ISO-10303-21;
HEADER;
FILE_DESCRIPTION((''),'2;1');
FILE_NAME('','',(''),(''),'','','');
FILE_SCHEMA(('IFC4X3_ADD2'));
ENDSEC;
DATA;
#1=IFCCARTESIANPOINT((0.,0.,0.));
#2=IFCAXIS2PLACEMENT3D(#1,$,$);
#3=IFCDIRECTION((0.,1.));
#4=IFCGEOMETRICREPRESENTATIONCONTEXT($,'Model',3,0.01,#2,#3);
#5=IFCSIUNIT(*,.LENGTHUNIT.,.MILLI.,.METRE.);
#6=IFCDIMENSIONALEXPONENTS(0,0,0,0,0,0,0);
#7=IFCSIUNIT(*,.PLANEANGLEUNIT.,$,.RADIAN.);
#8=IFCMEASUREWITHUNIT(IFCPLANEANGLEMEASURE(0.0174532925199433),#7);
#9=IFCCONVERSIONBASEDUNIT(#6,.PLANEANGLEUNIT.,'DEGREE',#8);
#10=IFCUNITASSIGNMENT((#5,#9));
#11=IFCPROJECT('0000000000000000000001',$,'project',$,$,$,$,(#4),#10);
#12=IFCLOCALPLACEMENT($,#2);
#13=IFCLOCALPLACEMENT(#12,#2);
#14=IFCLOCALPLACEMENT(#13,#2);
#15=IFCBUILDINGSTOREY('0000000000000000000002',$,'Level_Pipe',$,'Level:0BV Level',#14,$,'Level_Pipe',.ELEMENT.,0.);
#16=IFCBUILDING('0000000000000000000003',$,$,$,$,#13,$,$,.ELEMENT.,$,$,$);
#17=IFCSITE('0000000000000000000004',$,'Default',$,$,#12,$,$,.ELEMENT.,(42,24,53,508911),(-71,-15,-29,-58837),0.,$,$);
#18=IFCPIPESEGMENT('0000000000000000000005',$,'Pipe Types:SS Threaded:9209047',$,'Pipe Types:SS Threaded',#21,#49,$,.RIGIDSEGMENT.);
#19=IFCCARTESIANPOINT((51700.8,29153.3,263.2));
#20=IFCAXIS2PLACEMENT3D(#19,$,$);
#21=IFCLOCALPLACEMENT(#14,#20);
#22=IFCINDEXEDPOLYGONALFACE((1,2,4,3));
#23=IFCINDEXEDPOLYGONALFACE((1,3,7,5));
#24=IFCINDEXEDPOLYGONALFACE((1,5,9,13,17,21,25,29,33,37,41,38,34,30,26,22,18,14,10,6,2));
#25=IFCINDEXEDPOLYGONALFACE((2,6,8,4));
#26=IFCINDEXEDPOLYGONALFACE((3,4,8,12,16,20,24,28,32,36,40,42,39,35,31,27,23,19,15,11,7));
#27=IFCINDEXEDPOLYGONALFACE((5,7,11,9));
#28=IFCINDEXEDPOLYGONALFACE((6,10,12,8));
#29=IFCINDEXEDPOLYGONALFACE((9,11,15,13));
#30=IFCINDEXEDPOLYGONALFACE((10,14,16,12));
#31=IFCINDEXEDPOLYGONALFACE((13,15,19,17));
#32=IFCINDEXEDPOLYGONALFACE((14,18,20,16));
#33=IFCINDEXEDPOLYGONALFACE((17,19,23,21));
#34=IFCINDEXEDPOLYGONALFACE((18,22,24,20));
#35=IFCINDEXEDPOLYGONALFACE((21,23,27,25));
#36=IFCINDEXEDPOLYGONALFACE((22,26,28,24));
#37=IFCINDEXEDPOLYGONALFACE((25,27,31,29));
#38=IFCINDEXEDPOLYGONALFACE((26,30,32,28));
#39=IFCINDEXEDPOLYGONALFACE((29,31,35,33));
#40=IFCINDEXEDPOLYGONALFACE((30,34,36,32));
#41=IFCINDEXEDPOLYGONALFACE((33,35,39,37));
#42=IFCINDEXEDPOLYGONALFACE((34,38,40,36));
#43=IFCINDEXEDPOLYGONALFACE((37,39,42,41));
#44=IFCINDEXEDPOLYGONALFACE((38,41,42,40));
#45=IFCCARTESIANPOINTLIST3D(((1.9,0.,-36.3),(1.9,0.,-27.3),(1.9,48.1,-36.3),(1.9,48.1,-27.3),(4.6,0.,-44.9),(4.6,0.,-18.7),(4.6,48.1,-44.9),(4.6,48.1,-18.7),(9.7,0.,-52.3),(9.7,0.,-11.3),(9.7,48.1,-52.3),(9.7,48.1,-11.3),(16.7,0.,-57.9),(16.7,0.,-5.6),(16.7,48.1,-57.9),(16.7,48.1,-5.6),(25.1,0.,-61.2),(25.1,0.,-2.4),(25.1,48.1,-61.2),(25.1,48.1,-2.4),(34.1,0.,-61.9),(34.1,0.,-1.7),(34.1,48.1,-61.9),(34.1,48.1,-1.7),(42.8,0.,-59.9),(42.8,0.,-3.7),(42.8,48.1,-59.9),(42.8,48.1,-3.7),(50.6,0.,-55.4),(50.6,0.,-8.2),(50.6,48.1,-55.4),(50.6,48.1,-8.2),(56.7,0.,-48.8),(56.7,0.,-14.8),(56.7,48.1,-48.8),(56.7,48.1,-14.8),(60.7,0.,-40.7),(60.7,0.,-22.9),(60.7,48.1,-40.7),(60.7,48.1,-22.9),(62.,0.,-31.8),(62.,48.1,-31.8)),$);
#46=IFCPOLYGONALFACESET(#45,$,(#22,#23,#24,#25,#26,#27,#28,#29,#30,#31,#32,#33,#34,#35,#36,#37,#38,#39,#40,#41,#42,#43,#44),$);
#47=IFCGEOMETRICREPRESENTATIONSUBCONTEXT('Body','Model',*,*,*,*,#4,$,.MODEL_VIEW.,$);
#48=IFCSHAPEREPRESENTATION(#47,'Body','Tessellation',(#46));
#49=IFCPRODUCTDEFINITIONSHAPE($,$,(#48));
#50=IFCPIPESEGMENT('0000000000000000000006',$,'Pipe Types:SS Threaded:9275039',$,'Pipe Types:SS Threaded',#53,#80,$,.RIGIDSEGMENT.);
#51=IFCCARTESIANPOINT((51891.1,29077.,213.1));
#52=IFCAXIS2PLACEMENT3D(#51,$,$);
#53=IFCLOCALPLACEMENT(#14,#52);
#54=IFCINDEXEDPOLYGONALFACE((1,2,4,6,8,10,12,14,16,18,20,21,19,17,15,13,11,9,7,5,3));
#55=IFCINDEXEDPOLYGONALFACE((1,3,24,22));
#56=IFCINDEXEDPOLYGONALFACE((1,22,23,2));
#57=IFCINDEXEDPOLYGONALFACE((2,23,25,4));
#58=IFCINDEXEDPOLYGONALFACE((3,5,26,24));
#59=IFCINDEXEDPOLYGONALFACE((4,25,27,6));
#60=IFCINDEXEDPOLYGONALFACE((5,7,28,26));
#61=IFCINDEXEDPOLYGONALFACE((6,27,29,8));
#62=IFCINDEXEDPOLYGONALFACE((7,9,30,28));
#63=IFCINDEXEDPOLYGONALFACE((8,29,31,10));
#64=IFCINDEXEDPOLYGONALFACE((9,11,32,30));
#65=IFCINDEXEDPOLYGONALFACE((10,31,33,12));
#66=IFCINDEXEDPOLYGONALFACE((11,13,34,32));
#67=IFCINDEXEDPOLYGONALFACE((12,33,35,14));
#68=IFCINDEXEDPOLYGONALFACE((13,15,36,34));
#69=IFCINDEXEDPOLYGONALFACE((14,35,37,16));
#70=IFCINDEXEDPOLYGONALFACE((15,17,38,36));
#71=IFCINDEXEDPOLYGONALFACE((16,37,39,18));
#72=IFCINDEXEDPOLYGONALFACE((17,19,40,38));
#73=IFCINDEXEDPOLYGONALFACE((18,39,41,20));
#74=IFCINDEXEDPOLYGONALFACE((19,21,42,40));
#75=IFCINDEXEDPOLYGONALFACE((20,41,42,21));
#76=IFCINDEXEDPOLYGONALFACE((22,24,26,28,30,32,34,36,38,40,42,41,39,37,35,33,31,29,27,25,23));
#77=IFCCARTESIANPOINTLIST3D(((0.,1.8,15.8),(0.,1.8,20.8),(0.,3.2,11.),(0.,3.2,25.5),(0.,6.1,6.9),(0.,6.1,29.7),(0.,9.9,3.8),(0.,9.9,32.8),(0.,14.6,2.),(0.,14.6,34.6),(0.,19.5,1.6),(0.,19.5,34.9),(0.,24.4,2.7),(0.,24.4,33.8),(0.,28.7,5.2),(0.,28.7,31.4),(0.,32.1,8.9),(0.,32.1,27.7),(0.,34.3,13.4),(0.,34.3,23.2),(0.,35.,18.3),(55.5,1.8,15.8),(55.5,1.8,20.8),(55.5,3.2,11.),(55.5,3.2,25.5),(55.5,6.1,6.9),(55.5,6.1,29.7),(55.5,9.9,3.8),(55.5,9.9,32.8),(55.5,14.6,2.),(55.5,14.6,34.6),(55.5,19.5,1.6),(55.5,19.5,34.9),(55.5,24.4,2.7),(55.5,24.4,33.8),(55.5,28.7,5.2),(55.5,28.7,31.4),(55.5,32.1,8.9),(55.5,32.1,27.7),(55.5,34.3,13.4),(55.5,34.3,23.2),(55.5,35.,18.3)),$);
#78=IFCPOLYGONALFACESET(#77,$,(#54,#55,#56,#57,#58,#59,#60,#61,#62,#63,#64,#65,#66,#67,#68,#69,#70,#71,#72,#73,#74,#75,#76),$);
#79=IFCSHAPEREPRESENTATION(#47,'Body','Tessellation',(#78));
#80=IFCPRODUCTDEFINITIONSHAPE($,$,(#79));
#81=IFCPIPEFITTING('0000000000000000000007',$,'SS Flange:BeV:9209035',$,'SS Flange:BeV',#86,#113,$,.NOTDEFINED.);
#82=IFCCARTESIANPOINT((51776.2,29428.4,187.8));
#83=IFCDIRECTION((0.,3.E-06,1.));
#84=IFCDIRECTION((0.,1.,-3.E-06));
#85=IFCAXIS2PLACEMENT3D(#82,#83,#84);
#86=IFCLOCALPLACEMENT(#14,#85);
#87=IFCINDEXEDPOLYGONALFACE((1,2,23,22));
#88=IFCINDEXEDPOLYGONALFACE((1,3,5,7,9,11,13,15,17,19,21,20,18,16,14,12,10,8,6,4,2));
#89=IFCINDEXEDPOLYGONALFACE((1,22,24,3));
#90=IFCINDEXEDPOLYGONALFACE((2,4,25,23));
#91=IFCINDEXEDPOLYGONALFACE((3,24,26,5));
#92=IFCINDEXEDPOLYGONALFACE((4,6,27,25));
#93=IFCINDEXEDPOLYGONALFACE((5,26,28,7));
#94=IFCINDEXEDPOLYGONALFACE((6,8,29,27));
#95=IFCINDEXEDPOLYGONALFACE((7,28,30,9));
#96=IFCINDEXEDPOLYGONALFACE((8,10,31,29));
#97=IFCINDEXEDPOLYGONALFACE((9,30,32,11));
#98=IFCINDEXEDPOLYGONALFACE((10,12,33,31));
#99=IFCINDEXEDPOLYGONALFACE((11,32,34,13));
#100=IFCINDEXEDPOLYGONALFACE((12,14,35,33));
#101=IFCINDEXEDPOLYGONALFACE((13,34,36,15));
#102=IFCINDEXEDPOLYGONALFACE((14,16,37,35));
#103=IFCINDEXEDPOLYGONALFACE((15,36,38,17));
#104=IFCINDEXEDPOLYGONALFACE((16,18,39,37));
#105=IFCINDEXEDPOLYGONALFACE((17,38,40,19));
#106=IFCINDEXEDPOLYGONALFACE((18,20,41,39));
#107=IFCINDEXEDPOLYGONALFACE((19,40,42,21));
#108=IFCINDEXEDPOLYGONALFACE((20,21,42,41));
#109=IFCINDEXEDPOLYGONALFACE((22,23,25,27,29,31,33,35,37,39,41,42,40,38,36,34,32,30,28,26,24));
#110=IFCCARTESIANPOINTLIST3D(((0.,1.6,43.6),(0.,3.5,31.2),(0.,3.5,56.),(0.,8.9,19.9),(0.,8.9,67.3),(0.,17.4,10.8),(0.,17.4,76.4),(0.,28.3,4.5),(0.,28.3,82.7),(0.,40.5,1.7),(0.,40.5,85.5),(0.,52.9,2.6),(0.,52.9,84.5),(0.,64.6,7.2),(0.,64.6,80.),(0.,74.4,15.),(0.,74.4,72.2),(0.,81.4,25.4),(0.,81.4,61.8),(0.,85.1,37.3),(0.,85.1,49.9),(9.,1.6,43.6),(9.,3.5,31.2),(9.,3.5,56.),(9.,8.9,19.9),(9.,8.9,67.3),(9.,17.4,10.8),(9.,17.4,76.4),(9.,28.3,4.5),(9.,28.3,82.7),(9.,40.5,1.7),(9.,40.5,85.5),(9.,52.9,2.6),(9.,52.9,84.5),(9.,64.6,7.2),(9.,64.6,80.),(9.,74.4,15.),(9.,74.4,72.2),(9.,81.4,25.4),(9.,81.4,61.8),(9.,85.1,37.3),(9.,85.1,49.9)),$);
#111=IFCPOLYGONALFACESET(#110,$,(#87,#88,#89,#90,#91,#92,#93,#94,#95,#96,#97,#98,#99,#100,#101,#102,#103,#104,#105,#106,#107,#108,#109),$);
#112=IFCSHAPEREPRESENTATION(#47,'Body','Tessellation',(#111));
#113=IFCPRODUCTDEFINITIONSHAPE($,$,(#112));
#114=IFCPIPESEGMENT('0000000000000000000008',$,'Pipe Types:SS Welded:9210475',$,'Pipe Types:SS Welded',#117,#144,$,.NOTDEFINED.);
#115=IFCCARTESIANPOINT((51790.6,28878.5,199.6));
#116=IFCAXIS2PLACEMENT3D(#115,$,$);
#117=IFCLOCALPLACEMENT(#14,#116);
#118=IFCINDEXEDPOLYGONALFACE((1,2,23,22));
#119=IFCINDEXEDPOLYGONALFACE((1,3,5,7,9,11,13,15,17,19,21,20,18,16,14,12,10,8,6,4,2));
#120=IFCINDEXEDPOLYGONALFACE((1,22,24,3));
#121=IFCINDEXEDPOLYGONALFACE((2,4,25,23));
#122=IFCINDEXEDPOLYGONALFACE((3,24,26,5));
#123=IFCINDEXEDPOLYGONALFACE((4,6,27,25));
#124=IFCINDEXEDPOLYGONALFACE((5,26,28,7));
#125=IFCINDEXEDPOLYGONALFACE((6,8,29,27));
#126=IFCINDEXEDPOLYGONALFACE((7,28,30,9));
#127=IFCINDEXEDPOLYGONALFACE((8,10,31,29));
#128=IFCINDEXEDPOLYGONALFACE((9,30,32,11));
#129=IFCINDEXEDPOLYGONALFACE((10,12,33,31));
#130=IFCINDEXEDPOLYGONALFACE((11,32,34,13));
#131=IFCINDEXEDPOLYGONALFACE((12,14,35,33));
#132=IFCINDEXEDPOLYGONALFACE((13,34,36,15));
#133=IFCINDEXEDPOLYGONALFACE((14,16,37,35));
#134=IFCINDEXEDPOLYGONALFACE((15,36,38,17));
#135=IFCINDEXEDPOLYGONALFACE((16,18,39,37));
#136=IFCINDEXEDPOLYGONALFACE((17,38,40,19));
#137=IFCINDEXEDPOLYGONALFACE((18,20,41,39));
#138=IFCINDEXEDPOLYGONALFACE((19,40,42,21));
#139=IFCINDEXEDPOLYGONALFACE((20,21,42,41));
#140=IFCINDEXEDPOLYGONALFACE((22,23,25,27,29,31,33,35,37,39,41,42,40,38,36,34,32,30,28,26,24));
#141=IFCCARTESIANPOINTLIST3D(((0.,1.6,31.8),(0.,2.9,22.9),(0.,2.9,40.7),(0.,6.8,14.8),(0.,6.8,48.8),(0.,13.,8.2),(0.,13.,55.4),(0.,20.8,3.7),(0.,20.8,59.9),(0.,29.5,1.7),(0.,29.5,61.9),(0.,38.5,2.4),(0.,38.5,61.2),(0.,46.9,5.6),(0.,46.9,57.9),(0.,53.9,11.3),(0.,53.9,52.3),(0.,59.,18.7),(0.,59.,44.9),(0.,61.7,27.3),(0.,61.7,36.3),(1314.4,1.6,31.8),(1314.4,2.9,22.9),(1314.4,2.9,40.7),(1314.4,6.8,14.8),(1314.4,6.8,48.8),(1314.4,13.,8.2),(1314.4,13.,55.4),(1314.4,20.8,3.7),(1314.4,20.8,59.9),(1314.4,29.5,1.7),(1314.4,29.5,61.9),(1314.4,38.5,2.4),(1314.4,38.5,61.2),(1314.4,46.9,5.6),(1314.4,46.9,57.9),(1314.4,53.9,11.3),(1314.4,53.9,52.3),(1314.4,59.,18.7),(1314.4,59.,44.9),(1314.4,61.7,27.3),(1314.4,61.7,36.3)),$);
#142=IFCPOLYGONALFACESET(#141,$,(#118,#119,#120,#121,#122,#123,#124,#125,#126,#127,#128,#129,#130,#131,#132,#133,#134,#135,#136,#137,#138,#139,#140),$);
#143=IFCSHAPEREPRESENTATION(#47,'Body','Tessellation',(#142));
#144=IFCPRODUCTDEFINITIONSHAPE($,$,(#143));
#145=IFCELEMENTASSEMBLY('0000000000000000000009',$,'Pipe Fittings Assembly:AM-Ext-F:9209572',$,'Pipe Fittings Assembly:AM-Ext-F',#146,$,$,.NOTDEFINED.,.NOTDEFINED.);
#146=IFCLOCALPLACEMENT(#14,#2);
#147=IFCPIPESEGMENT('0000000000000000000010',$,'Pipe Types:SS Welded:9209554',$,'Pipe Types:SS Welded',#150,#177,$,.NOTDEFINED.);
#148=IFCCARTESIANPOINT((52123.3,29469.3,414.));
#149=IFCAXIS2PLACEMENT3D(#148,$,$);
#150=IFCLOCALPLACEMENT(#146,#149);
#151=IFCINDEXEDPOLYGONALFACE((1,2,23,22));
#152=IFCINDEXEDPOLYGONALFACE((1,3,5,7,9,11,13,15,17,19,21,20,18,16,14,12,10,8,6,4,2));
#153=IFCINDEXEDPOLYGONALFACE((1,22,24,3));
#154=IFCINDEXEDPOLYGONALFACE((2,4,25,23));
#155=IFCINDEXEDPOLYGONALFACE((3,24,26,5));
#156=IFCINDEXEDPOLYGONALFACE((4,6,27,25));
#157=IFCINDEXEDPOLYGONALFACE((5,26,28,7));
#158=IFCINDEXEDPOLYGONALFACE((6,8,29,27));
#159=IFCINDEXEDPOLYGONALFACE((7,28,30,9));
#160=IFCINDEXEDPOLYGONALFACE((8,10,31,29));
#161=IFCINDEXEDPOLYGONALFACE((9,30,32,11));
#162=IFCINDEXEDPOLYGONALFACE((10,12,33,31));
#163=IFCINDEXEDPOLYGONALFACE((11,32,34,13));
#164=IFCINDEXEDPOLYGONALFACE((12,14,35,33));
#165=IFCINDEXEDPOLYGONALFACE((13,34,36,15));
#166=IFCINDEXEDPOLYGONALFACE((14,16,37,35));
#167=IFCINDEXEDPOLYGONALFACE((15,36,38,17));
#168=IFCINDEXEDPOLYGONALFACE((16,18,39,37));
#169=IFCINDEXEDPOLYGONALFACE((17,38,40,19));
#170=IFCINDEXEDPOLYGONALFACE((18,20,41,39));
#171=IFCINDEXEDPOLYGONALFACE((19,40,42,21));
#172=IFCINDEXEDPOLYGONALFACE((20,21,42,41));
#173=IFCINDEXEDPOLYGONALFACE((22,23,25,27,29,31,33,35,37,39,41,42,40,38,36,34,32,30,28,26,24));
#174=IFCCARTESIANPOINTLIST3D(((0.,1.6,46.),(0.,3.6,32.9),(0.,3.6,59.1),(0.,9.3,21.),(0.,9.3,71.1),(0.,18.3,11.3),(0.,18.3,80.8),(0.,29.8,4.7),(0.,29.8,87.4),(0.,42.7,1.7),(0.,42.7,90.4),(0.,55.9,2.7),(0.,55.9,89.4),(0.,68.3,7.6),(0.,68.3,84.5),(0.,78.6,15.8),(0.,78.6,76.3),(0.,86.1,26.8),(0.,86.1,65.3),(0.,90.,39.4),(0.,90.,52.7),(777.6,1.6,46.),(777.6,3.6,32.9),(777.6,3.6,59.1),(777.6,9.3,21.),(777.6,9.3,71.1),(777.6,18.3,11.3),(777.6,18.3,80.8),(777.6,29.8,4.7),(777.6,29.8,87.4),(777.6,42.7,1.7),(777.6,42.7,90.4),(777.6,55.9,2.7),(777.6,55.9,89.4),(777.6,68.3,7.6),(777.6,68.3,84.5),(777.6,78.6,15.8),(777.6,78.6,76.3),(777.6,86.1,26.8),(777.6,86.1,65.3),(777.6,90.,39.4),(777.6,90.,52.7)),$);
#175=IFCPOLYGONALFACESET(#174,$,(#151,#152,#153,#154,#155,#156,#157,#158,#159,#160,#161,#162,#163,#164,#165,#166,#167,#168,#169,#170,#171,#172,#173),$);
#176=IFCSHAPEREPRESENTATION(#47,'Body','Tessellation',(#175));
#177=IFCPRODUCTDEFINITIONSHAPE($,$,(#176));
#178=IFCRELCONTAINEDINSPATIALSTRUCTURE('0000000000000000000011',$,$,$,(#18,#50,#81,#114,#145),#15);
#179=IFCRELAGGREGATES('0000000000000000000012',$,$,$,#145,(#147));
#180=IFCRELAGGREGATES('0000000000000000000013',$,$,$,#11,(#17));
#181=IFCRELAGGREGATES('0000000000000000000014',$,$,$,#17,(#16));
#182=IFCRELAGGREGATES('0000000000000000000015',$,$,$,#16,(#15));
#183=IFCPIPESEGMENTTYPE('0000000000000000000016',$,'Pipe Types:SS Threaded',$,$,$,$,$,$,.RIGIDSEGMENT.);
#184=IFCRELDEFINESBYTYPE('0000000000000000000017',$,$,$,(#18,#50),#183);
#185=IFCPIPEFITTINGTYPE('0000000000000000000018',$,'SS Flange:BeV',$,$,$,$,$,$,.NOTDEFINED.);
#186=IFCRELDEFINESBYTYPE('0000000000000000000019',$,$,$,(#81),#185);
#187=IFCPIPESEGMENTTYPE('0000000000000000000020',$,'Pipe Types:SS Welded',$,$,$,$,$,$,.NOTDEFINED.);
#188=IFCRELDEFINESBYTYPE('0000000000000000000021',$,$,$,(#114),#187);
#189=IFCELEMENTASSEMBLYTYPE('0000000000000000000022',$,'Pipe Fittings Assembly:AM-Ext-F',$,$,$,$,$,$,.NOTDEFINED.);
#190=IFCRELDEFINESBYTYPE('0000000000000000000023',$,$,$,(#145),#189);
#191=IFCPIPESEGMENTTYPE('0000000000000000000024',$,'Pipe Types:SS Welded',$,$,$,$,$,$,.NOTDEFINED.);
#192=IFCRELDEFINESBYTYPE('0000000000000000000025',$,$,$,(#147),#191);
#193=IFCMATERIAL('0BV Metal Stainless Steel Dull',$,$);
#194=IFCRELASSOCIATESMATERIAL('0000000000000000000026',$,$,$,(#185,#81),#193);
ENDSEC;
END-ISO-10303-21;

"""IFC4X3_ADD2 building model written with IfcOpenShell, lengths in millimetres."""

from ifc_helpers import new_model, entity, si_unit, converted_unit, direction, frame, frame_2d, origin, place, context, subcontext, project, spatial, circle, extrude, source, transform, mapped, material, type_object, type_shapes, element, aggregate, save


model = new_model("IFC4X3_ADD2")

# Units and contexts
model_context = context("Model", 3, precision=0.01, world=origin(), true_north=direction((0.0, 1.0)))
body_context = subcontext(model_context, "Body", "Model", "MODEL_VIEW")
ifc_project = project(units=[si_unit("LENGTHUNIT", "METRE", prefix="MILLI"), converted_unit("PLANEANGLEUNIT", "DEGREE", entity("IfcPlaneAngleMeasure", 0.0174532925199433), si_unit("PLANEANGLEUNIT", "RADIAN"), dimensions=[0, 0, 0, 0, 0, 0, 0])], contexts=[model_context])

# Site, building, storey
site_placement = place(None, origin())
site = spatial("IfcSite", under=ifc_project, at=site_placement, Name="Default", CompositionType="ELEMENT", RefLatitude=(42, 24, 53, 508911), RefLongitude=(-71, -15, -29, -58837), RefElevation=0.0)
building_placement = place(site_placement, origin())
building = spatial("IfcBuilding", under=site, at=building_placement, CompositionType="ELEMENT")
storey_placement = place(building_placement, origin())
storey = spatial("IfcBuildingStorey", under=building, at=storey_placement, Name="Level_Pipe", ObjectType="Level:0BV Level", LongName="Level_Pipe", CompositionType="ELEMENT", Elevation=0.0)

# Pipe segments
pipe_segment_type_1 = type_object("IfcPipeSegmentType", Name="Pipe Types:SS Threaded", PredefinedType="RIGIDSEGMENT")
pipe_segment_1_placement = place(storey_placement, frame((51700.8, 29153.3, 263.2)))
element("IfcPipeSegment", 1, at=pipe_segment_1_placement, inside=storey, type_object=pipe_segment_type_1, Name="Pipe Types:SS Threaded:9209047", ObjectType="Pipe Types:SS Threaded", PredefinedType="RIGIDSEGMENT", context=body_context, shape_type="SweptSolid", body=[
    extrude(circle(Radius=30.2, at=frame_2d((0.0, 0.0), x_axis=(1.0, 0.0))), frame((31.8, 0.0, -31.8), z_axis=(0.0, 1.0, 0.0), x_axis=(1.0, 0.0, 0.0)), (0.0, 0.0, 1.0), 48.1),
])
pipe_segment_2_placement = place(storey_placement, frame((51891.1, 29077.0, 213.1)))
element("IfcPipeSegment", 2, at=pipe_segment_2_placement, inside=storey, type_object=pipe_segment_type_1, Name="Pipe Types:SS Threaded:9275039", ObjectType="Pipe Types:SS Threaded", PredefinedType="RIGIDSEGMENT", context=body_context, shape_type="SweptSolid", body=[
    extrude(circle(Radius=16.7, at=frame_2d((0.0, 0.0), x_axis=(1.0, 0.0))), frame((0.0, 18.3, 18.3), z_axis=(1.0, 0.0, 0.0), x_axis=(0.0, 1.0, 0.0)), (0.0, 0.0, 1.0), 55.5),
])

# Pipe fitting
ifc_material_1 = material(Name="0BV Metal Stainless Steel Dull")
pipe_fitting_type_1 = type_object("IfcPipeFittingType", Name="SS Flange:BeV", PredefinedType="NOTDEFINED", material=ifc_material_1)
shared_shape_1 = source(origin(), body_context, "Body", "SweptSolid", [
    extrude(circle(Radius=42.0, at=frame_2d((0.0, 0.0), x_axis=(1.0, 0.0))), frame((0.0, 43.6, 43.6), z_axis=(1.0, 0.0, 0.0), x_axis=(0.0, -1.0, 0.0)), (0.0, 0.0, 1.0), 9.0),
])
type_shapes(pipe_fitting_type_1, [shared_shape_1])
pipe_fitting_1_placement = place(storey_placement, frame((51776.2, 29428.4, 187.8), z_axis=(0.0, 0.000003, 1.0), x_axis=(0.0, 1.0, -0.000003)))
element("IfcPipeFitting", 3, at=pipe_fitting_1_placement, inside=storey, type_object=pipe_fitting_type_1, material=ifc_material_1, Name="SS Flange:BeV:9209035", ObjectType="SS Flange:BeV", PredefinedType="NOTDEFINED", context=body_context, shape_type="MappedRepresentation", body=[
    mapped(shared_shape_1, transform((0.0, 0.0, 0.0), scale=1.0)),
])

# Pipe segment
pipe_segment_type_2 = type_object("IfcPipeSegmentType", Name="Pipe Types:SS Welded", PredefinedType="NOTDEFINED")
pipe_segment_3_placement = place(storey_placement, frame((51790.6, 28878.5, 199.6)))
element("IfcPipeSegment", 4, at=pipe_segment_3_placement, inside=storey, type_object=pipe_segment_type_2, Name="Pipe Types:SS Welded:9210475", ObjectType="Pipe Types:SS Welded", PredefinedType="NOTDEFINED", context=body_context, shape_type="SweptSolid", body=[
    extrude(circle(Radius=30.2, at=frame_2d((0.0, 0.0), x_axis=(1.0, 0.0))), frame((0.0, 31.8, 31.8), z_axis=(1.0, 0.0, 0.0), x_axis=(0.0, -1.0, 0.0)), (0.0, 0.0, 1.0), 1314.4),
])

# Element assembly, pipe segment
element_assembly_type = type_object("IfcElementAssemblyType", Name="Pipe Fittings Assembly:AM-Ext-F", PredefinedType="NOTDEFINED")
assembly_placement = place(storey_placement, origin())
assembly = element("IfcElementAssembly", 5, at=assembly_placement, inside=storey, type_object=element_assembly_type, Name="Pipe Fittings Assembly:AM-Ext-F:9209572", ObjectType="Pipe Fittings Assembly:AM-Ext-F", AssemblyPlace="NOTDEFINED", PredefinedType="NOTDEFINED")
pipe_segment_type_3 = type_object("IfcPipeSegmentType", Name="Pipe Types:SS Welded", PredefinedType="NOTDEFINED")
pipe_segment_4_placement = place(assembly_placement, frame((52123.3, 29469.3, 414.0)))
pipe_segment_4 = element("IfcPipeSegment", 6, at=pipe_segment_4_placement, type_object=pipe_segment_type_3, Name="Pipe Types:SS Welded:9209554", ObjectType="Pipe Types:SS Welded", PredefinedType="NOTDEFINED", context=body_context, shape_type="SweptSolid", body=[
    extrude(circle(Radius=44.5, at=frame_2d((0.0, 0.0), x_axis=(1.0, 0.0))), frame((0.0, 46.0, 46.0), z_axis=(1.0, 0.0, 0.0), x_axis=(0.0, -1.0, 0.0)), (0.0, 0.0, 1.0), 777.6),
])
aggregate(assembly, [pipe_segment_4])

save(model, "model.ifc")
